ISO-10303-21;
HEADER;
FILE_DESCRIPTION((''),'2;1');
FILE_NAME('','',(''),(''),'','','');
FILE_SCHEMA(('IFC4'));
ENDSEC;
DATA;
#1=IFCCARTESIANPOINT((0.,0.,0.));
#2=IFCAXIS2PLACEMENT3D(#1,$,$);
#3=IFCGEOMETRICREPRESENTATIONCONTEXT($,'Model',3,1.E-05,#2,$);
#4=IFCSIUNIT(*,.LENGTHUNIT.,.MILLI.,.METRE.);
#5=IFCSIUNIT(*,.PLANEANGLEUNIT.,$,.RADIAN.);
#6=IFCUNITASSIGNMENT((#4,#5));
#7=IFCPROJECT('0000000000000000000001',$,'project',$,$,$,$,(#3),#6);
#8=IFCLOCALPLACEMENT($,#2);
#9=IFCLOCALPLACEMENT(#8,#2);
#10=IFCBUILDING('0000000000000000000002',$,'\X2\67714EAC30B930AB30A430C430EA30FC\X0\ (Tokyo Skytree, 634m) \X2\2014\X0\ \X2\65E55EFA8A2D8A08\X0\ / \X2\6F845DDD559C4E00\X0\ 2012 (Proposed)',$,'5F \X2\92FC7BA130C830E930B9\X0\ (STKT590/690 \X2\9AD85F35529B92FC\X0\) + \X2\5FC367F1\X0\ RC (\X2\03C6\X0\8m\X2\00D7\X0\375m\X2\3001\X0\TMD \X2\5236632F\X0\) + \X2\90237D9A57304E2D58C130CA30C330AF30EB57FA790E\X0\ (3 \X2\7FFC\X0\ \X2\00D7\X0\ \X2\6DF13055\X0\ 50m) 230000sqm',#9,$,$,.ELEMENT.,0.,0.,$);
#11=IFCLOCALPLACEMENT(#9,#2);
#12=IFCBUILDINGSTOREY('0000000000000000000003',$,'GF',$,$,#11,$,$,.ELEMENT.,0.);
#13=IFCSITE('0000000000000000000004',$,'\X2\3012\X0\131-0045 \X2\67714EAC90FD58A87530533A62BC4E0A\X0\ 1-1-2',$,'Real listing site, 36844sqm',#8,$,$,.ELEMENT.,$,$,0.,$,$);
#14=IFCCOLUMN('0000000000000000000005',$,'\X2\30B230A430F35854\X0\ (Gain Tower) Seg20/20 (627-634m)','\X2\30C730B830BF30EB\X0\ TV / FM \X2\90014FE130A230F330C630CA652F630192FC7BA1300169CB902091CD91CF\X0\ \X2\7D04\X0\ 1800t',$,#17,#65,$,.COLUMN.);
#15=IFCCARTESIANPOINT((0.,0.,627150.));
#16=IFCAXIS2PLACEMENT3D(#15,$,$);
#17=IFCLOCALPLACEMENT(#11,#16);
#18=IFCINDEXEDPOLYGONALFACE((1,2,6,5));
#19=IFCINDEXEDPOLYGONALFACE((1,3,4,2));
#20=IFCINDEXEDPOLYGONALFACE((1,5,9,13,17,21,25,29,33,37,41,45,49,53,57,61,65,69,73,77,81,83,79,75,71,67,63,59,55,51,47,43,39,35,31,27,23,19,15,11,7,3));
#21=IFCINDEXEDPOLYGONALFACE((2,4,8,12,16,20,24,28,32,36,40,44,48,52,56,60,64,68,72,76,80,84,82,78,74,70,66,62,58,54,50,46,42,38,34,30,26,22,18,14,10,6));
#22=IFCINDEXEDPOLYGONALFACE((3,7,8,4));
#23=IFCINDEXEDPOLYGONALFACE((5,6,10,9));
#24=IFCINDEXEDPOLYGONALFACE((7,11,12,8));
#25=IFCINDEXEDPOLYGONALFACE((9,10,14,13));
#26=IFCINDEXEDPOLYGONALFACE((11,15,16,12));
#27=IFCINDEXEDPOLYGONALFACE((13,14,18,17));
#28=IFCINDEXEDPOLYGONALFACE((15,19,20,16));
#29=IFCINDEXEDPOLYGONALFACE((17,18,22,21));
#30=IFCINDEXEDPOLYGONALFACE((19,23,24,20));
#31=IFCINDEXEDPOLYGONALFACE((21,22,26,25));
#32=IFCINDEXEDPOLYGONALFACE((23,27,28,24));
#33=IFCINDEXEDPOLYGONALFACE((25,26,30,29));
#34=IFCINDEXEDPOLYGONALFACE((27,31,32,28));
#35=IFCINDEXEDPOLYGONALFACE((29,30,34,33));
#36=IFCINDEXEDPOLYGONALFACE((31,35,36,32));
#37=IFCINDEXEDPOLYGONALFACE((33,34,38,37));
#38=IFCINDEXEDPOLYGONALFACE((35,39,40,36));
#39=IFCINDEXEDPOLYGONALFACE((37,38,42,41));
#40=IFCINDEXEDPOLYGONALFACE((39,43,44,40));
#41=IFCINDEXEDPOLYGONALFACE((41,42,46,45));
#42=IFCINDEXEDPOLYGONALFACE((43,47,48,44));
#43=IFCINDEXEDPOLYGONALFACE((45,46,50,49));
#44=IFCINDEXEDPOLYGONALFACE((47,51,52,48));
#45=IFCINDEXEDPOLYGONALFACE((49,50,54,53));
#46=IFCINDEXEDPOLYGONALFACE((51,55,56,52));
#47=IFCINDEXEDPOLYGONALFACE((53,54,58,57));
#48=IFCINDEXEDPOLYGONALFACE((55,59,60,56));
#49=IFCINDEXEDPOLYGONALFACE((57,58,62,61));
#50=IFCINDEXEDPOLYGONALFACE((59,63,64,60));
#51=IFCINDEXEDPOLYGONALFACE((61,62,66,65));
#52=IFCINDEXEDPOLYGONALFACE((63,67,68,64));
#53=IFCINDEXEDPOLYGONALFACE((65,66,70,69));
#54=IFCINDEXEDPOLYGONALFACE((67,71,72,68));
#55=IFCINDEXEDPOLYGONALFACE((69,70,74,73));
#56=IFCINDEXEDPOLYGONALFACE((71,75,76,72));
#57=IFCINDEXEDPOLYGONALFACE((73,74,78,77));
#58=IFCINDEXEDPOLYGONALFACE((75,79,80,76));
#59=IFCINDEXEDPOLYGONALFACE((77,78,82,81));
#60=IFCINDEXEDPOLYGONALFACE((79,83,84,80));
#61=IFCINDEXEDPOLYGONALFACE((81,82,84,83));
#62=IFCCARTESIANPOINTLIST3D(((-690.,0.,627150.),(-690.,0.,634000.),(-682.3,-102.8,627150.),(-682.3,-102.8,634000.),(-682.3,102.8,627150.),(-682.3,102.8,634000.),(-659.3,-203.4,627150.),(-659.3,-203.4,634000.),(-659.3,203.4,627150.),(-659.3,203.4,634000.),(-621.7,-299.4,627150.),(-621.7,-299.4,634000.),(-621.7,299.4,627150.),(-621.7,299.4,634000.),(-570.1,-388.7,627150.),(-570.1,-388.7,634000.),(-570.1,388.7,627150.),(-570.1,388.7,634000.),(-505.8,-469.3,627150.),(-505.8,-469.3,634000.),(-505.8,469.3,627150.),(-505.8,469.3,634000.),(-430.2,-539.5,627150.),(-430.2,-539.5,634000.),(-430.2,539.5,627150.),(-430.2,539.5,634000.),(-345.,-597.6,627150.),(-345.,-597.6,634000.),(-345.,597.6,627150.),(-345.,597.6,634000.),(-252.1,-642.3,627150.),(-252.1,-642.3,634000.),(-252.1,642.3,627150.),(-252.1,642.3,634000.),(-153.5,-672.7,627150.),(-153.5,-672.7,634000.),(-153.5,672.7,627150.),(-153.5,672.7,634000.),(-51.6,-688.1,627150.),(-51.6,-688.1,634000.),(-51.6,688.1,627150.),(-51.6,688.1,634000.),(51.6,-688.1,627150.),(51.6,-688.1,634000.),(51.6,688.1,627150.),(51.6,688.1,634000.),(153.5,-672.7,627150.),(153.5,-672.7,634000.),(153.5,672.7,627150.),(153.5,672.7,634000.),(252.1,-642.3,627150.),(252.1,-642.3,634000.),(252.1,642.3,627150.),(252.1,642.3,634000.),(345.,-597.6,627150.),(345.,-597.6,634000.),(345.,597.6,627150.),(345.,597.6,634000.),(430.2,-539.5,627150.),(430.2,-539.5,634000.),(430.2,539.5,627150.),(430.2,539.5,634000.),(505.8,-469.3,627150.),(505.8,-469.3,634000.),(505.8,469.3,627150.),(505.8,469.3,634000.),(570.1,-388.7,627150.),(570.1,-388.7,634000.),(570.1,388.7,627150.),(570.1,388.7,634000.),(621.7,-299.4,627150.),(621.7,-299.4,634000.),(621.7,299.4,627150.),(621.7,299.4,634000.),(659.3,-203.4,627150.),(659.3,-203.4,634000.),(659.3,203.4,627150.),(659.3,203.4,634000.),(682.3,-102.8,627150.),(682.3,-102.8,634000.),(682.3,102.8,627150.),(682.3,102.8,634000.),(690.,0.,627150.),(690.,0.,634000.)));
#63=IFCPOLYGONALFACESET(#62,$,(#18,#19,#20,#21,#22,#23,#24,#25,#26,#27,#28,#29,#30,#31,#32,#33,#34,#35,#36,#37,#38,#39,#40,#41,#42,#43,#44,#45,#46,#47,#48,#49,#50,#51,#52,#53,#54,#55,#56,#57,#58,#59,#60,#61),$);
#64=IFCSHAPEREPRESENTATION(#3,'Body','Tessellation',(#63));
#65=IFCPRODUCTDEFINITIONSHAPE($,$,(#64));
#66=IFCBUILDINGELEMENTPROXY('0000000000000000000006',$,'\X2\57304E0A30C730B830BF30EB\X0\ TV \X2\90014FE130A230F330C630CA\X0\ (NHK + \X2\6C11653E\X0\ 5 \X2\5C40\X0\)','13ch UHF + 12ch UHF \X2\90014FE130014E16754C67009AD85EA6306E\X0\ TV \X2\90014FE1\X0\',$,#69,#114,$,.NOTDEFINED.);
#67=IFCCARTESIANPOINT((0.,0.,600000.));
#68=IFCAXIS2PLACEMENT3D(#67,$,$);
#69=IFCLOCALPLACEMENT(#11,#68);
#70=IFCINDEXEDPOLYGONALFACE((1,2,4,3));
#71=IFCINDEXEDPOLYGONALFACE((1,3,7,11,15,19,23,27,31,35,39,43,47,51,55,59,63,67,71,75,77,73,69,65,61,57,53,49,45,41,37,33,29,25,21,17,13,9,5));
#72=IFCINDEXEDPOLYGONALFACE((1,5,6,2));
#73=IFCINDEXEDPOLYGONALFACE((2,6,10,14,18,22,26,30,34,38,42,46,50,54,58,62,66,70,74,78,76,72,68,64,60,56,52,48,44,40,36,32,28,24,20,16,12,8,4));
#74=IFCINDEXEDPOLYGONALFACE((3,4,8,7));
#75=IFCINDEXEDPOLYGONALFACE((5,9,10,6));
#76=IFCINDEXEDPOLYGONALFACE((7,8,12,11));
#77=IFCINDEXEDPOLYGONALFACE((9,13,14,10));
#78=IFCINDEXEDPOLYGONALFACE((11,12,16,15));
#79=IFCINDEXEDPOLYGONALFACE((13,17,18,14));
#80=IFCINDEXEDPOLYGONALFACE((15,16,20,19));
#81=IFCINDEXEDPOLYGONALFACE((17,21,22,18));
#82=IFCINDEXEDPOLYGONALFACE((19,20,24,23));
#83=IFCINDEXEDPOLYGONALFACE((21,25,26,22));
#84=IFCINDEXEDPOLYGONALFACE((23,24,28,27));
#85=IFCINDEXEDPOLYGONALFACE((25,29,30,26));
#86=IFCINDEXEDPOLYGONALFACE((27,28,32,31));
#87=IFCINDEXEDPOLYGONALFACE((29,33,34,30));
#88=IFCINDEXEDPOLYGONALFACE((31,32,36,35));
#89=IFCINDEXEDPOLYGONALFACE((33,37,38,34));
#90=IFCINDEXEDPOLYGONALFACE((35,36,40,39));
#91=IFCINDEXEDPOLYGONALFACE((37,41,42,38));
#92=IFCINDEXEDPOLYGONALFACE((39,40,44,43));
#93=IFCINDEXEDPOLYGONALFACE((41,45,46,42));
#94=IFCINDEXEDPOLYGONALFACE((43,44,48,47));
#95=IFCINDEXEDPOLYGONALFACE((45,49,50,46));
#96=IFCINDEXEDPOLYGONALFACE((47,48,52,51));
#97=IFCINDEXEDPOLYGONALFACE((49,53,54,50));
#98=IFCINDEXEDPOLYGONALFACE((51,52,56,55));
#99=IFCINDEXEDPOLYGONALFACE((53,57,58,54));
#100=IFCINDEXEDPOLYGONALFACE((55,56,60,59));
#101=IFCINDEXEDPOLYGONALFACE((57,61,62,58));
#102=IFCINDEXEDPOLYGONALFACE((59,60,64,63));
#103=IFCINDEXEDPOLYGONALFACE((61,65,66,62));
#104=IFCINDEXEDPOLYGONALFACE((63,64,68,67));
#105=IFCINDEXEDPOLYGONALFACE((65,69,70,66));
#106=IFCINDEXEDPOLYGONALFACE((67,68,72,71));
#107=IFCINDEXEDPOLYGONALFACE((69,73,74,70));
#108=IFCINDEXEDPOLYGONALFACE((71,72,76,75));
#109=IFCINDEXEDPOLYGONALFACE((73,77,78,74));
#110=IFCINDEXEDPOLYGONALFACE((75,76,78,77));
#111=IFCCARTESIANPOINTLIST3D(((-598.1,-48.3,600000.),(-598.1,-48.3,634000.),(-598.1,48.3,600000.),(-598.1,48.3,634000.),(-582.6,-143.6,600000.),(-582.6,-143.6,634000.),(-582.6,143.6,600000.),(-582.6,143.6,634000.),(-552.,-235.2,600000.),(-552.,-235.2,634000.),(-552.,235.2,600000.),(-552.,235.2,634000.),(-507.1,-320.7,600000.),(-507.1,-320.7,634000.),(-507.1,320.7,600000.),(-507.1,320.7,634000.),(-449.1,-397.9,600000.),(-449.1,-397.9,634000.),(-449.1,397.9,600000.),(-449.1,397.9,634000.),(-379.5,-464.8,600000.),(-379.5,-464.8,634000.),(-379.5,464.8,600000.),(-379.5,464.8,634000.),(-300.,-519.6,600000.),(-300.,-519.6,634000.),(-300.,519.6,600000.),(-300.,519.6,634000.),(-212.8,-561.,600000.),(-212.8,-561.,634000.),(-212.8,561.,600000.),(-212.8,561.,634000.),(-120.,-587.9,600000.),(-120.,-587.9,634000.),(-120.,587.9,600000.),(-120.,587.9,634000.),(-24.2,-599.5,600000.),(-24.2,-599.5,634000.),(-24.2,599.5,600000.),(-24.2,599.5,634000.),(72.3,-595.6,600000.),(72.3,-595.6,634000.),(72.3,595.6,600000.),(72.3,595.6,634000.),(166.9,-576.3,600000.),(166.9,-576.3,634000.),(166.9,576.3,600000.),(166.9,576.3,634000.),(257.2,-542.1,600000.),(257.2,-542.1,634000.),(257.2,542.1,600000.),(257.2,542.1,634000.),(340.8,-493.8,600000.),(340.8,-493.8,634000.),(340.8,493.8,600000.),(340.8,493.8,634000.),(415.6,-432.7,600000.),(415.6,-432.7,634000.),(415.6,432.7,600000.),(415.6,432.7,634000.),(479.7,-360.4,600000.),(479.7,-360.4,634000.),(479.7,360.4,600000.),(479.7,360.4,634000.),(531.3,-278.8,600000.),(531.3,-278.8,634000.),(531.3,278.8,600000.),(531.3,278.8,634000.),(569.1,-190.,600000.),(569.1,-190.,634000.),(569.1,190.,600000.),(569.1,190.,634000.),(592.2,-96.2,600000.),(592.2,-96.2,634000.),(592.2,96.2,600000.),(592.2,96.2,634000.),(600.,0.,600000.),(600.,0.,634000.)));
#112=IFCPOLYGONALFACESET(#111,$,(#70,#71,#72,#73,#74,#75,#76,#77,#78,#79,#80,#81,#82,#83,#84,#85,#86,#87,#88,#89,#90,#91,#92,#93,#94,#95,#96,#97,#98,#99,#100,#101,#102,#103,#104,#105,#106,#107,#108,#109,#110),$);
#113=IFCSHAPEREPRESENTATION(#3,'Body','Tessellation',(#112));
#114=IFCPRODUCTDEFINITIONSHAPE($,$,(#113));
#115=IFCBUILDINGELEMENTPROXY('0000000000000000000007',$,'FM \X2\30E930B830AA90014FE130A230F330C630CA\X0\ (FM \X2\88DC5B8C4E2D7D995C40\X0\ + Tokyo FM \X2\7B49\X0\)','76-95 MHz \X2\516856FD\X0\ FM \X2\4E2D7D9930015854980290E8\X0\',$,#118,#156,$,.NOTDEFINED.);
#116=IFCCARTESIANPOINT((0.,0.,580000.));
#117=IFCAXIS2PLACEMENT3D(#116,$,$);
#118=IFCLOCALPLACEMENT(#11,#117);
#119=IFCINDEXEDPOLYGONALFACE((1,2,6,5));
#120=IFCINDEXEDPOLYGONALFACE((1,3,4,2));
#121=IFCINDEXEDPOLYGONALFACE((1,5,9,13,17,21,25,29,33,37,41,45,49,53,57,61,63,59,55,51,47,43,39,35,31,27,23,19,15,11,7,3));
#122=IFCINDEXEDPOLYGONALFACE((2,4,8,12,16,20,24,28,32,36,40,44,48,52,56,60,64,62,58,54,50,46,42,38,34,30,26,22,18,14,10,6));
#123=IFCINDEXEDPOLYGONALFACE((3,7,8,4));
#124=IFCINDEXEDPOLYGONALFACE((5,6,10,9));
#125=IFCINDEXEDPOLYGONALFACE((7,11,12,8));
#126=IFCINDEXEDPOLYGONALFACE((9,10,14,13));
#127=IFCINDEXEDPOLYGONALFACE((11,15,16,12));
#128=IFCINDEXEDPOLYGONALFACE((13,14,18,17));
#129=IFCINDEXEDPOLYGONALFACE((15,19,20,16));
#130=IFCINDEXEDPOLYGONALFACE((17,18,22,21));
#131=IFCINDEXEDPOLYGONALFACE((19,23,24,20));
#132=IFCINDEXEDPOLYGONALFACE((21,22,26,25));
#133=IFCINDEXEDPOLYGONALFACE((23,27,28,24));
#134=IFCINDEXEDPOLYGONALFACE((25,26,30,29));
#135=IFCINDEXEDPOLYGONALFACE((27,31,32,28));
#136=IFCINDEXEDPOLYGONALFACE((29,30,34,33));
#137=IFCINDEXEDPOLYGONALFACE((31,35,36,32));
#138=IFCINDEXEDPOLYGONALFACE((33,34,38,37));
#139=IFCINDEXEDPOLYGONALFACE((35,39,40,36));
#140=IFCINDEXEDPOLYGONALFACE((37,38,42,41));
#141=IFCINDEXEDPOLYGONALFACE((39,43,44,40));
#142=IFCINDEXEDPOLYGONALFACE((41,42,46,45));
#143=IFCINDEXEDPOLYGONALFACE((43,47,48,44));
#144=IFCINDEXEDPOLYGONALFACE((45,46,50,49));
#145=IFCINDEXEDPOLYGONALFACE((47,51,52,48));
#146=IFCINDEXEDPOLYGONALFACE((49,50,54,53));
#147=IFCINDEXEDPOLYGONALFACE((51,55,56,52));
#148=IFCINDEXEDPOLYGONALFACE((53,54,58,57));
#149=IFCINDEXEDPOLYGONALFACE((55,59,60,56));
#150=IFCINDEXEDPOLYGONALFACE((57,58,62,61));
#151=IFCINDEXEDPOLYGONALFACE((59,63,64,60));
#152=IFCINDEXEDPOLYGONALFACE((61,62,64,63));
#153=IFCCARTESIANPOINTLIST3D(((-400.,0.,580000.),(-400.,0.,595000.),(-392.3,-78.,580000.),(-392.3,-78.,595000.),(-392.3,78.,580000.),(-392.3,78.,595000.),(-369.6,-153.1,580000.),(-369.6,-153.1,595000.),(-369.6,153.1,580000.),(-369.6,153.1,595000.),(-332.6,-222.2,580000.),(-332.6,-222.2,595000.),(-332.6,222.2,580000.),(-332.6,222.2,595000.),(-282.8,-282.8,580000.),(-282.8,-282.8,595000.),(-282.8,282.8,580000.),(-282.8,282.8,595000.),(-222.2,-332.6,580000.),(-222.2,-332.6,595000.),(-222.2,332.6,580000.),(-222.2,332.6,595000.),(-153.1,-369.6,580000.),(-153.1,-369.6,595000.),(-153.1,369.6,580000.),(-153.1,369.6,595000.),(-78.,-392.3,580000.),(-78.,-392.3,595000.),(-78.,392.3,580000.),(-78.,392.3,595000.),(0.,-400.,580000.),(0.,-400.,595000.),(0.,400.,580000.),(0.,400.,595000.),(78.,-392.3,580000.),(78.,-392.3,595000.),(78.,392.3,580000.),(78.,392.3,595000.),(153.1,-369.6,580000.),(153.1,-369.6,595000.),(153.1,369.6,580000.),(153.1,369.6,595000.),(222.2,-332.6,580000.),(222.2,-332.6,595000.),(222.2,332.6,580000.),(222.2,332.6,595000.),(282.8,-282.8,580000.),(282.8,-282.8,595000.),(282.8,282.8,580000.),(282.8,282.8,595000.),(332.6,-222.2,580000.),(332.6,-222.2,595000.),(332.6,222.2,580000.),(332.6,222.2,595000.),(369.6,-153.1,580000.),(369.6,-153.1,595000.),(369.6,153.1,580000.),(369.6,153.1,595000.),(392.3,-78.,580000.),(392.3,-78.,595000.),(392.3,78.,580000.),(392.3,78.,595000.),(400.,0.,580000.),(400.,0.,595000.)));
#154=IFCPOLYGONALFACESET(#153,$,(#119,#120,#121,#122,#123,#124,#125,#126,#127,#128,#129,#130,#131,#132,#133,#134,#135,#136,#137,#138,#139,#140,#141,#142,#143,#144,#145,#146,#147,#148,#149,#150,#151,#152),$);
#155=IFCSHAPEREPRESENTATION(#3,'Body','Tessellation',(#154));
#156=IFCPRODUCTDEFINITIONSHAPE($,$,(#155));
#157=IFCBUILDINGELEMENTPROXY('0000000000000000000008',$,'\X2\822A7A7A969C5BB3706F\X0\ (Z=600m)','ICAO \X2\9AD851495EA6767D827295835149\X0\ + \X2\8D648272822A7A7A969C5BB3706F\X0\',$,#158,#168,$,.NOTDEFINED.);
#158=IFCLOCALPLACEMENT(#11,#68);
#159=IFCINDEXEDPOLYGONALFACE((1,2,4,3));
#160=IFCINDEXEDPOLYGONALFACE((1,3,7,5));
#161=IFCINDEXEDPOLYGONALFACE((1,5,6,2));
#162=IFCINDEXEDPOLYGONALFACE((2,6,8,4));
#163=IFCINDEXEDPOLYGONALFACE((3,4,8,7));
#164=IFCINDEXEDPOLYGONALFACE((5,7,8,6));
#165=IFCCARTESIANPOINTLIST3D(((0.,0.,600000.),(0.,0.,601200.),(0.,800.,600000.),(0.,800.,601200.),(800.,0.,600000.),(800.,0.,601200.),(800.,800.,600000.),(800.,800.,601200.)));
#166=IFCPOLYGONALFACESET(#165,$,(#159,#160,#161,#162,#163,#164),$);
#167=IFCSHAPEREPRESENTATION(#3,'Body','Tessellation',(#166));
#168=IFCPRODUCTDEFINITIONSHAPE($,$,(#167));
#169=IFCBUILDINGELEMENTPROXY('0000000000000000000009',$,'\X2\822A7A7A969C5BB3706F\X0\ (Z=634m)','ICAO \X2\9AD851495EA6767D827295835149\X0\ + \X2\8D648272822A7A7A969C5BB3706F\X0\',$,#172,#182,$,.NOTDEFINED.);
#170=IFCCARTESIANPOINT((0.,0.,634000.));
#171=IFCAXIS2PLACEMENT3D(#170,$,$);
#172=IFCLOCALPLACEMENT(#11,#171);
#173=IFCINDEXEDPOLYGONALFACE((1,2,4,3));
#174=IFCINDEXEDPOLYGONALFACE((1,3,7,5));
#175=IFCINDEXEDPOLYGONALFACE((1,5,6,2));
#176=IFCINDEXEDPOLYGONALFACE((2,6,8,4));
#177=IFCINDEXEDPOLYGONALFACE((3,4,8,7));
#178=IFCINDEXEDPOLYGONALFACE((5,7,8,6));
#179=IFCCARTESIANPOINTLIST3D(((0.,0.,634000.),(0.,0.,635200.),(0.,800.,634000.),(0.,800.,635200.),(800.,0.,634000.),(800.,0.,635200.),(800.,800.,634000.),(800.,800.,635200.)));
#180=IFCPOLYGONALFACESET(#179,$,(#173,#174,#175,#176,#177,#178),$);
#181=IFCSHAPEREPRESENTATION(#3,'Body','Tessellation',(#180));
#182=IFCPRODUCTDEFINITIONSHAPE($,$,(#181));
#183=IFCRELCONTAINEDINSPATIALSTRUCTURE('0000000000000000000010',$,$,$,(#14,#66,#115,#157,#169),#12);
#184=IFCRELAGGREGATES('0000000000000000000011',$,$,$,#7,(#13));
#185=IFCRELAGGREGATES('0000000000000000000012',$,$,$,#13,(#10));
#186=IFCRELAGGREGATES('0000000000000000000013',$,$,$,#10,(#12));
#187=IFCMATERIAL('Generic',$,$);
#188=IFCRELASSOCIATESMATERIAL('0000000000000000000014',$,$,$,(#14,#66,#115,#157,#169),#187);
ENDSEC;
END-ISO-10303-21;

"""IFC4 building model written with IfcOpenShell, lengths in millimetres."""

from ifc_helpers import new_model, si_unit, frame, frame_2d, origin, origin_2d, place, context, project, spatial, rectangle, circle, extrude, material, element, save


model = new_model("IFC4")

# Units and contexts
model_context = context("Model", 3, precision=1e-05, world=origin())
ifc_project = project(units=[si_unit("LENGTHUNIT", "METRE", prefix="MILLI"), si_unit("PLANEANGLEUNIT", "RADIAN")], contexts=[model_context])

# Site, building, storey
site_placement = place(None, origin())
site = spatial("IfcSite", under=ifc_project, at=site_placement, Name="〒131-0045 東京都墨田区押上 1-1-2", ObjectType="Real listing site, 36844sqm", CompositionType="ELEMENT", RefElevation=0.0)
building_placement = place(site_placement, origin())
building = spatial("IfcBuilding", under=site, at=building_placement, Name="東京スカイツリー (Tokyo Skytree, 634m) — 日建設計 / 澄川喜一 2012 (Proposed)", ObjectType="5F 鋼管トラス (STKT590/690 高張力鋼) + 心柱 RC (φ8m×375m、TMD 制振) + 連続地中壁ナックル基礎 (3 翼 × 深さ 50m) 230000sqm", CompositionType="ELEMENT", ElevationOfRefHeight=0.0, ElevationOfTerrain=0.0)
storey_placement = place(building_placement, origin())
storey = spatial("IfcBuildingStorey", under=building, at=storey_placement, Name="GF", CompositionType="ELEMENT", Elevation=0.0)

# Column
ifc_material = material(Name="Generic")
column_1_placement = place(storey_placement, frame((0.0, 0.0, 627150.0)))
element("IfcColumn", 1, at=column_1_placement, inside=storey, material=ifc_material, Name="ゲイン塔 (Gain Tower) Seg20/20 (627-634m)", Description="デジタル TV / FM 送信アンテナ支持鋼管、構造重量 約 1800t", PredefinedType="COLUMN", context=model_context, shape_type="SweptSolid", body=[
    extrude(circle(Radius=690.0, at=origin_2d()), frame((0.0, 0.0, 627150.0)), (0.0, 0.0, 1.0), 6850.0),
])

# Building element proxies
proxy_1_placement = place(storey_placement, frame((0.0, 0.0, 600000.0)))
element("IfcBuildingElementProxy", 2, at=proxy_1_placement, inside=storey, material=ifc_material, Name="地上デジタル TV 送信アンテナ (NHK + 民放 5 局)", Description="13ch UHF + 12ch UHF 送信、世界最高度の TV 送信", PredefinedType="NOTDEFINED", context=model_context, shape_type="SweptSolid", body=[
    extrude(circle(Radius=600.0, at=origin_2d()), frame((0.0, 0.0, 600000.0)), (0.0, 0.0, 1.0), 34000.0),
])
proxy_2_placement = place(storey_placement, frame((0.0, 0.0, 580000.0)))
element("IfcBuildingElementProxy", 3, at=proxy_2_placement, inside=storey, material=ifc_material, Name="FM ラジオ送信アンテナ (FM 補完中継局 + Tokyo FM 等)", Description="76-95 MHz 全国 FM 中継、塔頂部", PredefinedType="NOTDEFINED", context=model_context, shape_type="SweptSolid", body=[
    extrude(circle(Radius=400.0, at=origin_2d()), frame((0.0, 0.0, 580000.0)), (0.0, 0.0, 1.0), 15000.0),
])
proxy_3_placement = place(storey_placement, frame((0.0, 0.0, 600000.0)))
element("IfcBuildingElementProxy", 4, at=proxy_3_placement, inside=storey, material=ifc_material, Name="航空障害灯 (Z=600m)", Description="ICAO 高光度白色閃光 + 赤色航空障害灯", PredefinedType="NOTDEFINED", context=model_context, shape_type="SweptSolid", body=[
    extrude(rectangle(XDim=800.0, YDim=800.0, at=frame_2d((400.0, 400.0))), frame((0.0, 0.0, 600000.0)), (0.0, 0.0, 1.0), 1200.0),
])
proxy_4_placement = place(storey_placement, frame((0.0, 0.0, 634000.0)))
element("IfcBuildingElementProxy", 5, at=proxy_4_placement, inside=storey, material=ifc_material, Name="航空障害灯 (Z=634m)", Description="ICAO 高光度白色閃光 + 赤色航空障害灯", PredefinedType="NOTDEFINED", context=model_context, shape_type="SweptSolid", body=[
    extrude(rectangle(XDim=800.0, YDim=800.0, at=frame_2d((400.0, 400.0))), frame((0.0, 0.0, 634000.0)), (0.0, 0.0, 1.0), 1200.0),
])

save(model, "model.ifc")
